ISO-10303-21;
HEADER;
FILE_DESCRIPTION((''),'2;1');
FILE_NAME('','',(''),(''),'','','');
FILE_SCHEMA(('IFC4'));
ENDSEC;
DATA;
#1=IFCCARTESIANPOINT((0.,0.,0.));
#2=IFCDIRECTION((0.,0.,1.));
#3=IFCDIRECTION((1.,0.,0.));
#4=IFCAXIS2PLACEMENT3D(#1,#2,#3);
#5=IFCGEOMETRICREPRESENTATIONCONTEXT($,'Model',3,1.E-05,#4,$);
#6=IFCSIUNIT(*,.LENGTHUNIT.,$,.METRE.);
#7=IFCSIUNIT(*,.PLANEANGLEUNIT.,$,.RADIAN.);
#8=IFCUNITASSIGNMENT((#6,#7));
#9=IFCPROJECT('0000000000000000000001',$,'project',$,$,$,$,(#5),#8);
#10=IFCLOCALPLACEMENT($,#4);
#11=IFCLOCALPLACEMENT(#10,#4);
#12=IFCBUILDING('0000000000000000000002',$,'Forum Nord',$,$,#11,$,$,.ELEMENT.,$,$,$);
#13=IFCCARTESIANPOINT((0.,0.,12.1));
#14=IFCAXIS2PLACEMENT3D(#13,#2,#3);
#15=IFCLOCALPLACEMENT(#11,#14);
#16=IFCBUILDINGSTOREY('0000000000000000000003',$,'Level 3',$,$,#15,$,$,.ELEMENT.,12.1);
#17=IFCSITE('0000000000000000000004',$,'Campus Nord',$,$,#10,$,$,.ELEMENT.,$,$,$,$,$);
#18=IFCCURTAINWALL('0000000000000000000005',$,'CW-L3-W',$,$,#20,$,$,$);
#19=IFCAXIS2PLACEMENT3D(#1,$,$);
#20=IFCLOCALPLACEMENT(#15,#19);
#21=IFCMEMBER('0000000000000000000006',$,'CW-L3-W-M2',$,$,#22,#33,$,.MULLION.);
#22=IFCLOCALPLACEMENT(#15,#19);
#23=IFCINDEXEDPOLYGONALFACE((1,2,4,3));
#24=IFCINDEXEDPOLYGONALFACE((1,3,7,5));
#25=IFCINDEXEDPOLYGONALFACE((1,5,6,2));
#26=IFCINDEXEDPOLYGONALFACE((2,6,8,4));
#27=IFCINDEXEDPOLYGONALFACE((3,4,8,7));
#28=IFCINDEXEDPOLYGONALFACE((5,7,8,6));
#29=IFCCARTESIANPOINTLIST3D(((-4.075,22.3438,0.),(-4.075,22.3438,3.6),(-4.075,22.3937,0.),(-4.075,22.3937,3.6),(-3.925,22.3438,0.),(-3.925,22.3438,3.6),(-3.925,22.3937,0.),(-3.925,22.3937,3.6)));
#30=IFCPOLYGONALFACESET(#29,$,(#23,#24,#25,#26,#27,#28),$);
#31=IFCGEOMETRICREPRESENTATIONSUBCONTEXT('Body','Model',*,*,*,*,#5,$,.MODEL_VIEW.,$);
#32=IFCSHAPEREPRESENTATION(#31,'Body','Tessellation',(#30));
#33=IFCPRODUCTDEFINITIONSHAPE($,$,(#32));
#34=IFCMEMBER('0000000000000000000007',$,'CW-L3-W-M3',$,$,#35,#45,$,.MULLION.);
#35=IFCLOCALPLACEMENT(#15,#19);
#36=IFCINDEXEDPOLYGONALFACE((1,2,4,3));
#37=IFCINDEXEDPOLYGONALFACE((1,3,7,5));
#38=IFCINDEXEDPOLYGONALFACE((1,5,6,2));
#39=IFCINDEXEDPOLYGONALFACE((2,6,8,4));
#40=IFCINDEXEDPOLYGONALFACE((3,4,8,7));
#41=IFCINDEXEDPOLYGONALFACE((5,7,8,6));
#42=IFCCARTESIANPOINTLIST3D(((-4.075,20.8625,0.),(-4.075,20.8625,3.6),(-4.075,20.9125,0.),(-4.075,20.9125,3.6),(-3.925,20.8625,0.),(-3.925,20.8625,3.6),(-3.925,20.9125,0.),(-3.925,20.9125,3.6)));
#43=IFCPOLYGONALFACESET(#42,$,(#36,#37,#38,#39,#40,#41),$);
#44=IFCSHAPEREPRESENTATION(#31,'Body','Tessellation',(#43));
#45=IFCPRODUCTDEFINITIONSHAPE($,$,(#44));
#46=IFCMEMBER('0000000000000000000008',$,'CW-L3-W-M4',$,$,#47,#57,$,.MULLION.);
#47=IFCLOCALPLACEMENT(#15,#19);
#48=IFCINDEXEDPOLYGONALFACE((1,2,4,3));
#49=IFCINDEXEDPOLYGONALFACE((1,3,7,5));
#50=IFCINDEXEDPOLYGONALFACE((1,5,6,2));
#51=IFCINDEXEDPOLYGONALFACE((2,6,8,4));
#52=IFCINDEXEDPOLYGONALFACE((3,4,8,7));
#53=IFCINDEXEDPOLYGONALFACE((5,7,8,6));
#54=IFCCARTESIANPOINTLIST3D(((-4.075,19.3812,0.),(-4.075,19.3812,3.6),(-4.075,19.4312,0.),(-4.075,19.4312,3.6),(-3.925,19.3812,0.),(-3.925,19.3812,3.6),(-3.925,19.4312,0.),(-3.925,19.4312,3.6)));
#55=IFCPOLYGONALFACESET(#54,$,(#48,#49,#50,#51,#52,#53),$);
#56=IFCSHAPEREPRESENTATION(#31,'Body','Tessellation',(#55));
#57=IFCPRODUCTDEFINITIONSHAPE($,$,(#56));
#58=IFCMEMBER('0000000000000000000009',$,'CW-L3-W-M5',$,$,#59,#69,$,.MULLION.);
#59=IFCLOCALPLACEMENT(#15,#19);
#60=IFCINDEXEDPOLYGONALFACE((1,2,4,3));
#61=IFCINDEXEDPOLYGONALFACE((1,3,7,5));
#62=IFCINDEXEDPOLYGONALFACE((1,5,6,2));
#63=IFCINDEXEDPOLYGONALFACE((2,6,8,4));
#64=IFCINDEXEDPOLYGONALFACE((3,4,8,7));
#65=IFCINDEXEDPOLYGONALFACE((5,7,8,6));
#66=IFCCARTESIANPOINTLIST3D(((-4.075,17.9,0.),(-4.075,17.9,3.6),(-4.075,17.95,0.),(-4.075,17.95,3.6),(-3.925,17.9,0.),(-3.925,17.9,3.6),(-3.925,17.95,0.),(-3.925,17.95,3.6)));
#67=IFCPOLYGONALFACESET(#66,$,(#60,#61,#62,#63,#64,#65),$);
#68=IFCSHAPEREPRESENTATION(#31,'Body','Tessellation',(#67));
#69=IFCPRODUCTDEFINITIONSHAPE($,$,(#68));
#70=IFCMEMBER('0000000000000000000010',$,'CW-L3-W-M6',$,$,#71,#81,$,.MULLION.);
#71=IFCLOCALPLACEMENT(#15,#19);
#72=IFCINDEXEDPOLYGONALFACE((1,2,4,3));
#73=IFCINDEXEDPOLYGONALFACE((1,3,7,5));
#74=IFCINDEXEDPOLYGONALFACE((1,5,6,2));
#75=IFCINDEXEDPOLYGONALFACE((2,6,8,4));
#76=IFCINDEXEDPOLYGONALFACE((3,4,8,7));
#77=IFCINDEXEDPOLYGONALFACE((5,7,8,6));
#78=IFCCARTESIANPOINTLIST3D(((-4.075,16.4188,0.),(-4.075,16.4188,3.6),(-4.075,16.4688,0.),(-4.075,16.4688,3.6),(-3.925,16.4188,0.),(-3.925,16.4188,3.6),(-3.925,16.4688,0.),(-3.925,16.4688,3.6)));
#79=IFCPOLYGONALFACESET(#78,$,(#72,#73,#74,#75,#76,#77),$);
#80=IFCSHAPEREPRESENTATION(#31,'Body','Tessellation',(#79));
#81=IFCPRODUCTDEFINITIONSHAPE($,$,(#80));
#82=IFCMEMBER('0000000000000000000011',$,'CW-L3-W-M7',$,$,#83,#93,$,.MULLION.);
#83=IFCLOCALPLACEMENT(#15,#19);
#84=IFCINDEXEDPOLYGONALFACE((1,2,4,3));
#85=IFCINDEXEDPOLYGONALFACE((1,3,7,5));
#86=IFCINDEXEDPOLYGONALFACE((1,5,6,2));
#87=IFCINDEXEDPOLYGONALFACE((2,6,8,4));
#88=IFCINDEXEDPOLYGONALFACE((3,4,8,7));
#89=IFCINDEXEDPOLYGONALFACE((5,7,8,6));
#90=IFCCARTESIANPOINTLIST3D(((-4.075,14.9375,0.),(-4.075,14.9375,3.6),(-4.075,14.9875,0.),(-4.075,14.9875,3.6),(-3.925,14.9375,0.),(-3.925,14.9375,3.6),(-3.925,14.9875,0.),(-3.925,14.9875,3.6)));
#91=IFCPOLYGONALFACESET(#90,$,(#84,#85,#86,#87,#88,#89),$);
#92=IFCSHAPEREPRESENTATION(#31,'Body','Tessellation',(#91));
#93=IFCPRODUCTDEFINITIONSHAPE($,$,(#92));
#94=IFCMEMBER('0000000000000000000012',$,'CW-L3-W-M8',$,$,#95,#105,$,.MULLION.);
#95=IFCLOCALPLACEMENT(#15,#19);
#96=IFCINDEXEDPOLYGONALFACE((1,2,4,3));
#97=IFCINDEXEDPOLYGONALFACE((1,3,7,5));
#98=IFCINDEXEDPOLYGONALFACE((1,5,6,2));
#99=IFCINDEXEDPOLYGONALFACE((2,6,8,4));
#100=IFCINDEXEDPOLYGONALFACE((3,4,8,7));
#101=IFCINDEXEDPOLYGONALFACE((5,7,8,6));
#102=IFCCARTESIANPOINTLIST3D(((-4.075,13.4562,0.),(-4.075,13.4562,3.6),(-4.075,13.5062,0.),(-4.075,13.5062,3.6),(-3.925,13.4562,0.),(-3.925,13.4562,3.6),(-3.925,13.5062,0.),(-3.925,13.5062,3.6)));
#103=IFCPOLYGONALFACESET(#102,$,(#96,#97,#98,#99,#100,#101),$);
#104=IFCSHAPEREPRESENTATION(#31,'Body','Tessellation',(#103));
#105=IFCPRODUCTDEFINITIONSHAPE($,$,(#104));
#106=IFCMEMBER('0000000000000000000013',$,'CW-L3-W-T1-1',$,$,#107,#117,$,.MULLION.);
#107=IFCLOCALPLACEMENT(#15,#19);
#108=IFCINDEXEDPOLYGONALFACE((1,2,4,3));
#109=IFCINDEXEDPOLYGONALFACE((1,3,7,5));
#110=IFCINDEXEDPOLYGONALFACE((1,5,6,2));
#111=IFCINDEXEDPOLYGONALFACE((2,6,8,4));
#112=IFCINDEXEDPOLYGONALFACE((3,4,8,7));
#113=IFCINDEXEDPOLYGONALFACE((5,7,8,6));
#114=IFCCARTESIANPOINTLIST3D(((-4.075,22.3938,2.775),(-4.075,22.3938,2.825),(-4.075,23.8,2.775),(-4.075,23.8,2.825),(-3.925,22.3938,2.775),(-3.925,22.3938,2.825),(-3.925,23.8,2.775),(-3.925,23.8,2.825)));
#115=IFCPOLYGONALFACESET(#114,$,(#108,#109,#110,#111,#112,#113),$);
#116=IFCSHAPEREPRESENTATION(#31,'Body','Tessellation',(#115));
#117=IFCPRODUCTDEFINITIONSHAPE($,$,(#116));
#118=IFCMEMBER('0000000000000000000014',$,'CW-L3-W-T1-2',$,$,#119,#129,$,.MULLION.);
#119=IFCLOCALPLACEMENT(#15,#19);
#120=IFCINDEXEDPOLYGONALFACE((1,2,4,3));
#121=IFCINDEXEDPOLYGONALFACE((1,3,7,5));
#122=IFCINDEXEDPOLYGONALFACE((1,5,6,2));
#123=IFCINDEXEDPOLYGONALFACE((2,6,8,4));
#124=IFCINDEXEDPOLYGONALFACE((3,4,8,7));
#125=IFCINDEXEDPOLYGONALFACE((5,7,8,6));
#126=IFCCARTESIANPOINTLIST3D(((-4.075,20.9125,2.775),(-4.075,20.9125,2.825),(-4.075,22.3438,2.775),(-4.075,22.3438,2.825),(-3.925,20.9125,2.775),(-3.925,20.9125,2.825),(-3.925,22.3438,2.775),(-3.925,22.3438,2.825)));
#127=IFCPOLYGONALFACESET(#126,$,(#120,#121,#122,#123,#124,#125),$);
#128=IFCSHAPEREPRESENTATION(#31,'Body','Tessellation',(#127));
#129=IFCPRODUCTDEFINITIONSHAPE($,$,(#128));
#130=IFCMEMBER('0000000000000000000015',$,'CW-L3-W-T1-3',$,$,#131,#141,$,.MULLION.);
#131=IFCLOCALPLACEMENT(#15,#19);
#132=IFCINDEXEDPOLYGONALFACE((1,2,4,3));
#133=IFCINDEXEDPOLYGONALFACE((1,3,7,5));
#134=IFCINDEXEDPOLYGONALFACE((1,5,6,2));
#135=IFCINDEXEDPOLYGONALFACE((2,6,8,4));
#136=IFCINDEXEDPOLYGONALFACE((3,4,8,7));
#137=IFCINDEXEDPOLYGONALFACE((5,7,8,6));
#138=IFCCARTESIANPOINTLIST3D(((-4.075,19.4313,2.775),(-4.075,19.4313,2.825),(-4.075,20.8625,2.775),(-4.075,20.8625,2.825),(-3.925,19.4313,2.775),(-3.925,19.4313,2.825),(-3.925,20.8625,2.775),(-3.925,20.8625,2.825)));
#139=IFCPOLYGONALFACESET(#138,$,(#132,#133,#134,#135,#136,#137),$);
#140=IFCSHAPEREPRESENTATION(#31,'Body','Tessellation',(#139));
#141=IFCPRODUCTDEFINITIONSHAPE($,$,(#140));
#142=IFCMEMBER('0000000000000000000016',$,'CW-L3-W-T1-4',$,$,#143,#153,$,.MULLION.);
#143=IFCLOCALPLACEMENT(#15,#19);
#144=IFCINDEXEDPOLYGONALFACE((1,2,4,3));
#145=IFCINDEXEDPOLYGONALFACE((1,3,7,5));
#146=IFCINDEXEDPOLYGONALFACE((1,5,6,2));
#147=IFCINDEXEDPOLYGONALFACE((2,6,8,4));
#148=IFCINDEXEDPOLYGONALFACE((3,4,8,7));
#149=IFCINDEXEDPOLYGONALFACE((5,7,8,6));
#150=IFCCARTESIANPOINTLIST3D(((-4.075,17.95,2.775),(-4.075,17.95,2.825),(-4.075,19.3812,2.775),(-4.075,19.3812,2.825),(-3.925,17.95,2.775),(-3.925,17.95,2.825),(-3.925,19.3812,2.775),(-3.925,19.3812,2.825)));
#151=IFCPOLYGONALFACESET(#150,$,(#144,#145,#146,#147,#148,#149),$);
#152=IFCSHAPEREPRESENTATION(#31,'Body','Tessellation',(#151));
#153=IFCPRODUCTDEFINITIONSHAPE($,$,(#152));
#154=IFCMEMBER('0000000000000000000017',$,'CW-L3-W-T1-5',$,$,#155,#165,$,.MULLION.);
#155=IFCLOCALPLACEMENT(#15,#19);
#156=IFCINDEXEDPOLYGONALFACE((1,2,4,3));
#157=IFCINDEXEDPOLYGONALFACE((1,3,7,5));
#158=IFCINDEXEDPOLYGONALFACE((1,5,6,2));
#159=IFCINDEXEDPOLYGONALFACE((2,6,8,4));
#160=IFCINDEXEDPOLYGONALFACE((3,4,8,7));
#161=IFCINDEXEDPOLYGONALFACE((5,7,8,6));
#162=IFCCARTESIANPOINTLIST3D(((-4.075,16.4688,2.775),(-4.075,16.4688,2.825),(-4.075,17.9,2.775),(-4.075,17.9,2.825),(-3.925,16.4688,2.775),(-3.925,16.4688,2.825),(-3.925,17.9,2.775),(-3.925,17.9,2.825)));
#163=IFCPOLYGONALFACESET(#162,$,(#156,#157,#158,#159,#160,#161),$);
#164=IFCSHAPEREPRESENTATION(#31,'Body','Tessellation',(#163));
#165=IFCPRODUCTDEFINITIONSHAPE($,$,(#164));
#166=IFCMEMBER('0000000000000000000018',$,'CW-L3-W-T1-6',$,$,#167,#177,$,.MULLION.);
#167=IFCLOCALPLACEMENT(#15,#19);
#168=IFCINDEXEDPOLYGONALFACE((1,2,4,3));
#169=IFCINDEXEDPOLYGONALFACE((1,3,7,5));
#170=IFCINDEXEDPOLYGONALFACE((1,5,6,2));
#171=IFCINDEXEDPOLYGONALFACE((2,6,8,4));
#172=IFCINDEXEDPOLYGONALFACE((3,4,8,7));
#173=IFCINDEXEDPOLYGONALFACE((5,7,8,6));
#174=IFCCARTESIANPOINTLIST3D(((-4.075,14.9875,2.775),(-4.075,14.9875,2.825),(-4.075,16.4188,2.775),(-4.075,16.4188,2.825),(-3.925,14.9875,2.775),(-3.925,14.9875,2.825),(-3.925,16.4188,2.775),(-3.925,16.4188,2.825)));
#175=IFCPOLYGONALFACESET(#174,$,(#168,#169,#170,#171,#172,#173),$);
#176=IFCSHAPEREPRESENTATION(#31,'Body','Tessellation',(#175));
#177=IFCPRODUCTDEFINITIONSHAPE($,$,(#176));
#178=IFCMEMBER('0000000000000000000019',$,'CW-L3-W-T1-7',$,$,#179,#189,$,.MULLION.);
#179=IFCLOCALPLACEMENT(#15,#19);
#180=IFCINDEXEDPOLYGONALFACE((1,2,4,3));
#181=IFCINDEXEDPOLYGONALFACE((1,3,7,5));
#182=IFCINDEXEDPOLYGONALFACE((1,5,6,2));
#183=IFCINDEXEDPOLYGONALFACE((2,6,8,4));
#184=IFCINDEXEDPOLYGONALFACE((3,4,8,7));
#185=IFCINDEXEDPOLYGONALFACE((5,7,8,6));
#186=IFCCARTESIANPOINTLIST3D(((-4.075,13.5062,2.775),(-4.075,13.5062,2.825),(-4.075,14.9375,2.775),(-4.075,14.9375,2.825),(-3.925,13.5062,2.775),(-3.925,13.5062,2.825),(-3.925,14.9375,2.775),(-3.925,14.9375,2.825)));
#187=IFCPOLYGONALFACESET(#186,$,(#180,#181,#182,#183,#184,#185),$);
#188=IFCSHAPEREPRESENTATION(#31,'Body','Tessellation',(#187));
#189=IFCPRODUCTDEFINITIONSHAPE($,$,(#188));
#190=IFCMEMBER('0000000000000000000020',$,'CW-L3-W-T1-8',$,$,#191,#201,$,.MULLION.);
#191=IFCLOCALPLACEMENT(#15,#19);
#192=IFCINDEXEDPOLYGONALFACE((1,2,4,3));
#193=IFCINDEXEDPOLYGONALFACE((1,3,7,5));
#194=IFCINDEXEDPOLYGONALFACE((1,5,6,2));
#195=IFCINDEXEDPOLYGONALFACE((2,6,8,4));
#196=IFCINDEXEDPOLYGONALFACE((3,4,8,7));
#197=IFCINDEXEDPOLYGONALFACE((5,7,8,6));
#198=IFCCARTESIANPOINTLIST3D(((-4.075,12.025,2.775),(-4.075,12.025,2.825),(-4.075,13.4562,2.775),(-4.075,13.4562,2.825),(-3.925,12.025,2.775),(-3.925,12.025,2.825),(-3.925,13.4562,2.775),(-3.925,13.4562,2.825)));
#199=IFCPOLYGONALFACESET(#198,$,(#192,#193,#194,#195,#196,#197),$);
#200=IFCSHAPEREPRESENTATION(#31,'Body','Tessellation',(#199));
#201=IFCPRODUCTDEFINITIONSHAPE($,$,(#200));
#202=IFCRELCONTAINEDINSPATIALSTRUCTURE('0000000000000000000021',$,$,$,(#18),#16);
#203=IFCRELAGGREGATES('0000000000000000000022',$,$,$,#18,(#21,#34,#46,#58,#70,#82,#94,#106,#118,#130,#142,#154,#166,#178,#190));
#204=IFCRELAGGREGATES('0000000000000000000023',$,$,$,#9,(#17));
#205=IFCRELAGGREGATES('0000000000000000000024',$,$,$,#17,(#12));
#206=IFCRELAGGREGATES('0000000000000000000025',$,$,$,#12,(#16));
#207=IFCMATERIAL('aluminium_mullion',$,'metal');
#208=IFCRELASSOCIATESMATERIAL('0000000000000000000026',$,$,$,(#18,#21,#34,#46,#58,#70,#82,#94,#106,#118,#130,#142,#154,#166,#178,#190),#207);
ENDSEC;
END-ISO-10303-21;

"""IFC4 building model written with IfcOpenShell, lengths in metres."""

from ifc_helpers import new_model, si_unit, frame, origin_with_axes, origin_2d_with_axis, place, context, subcontext, project, spatial, rectangle, extrude, material, element, aggregate, save


model = new_model("IFC4")

# Units and contexts
model_context = context("Model", 3, precision=1e-05, world=origin_with_axes())
body_context = subcontext(model_context, "Body", "Model", "MODEL_VIEW")
ifc_project = project(units=[si_unit("LENGTHUNIT", "METRE"), si_unit("PLANEANGLEUNIT", "RADIAN")], contexts=[model_context])

# Site, building, storey
site_placement = place(None, origin_with_axes())
site = spatial("IfcSite", under=ifc_project, at=site_placement, Name="Campus Nord", CompositionType="ELEMENT")
building_placement = place(site_placement, origin_with_axes())
building = spatial("IfcBuilding", under=site, at=building_placement, Name="Forum Nord", CompositionType="ELEMENT")
storey_placement = place(building_placement, frame((0.0, 0.0, 12.1), z_axis=(0.0, 0.0, 1.0), x_axis=(1.0, 0.0, 0.0)))
storey = spatial("IfcBuildingStorey", under=building, at=storey_placement, Name="Level 3", CompositionType="ELEMENT", Elevation=12.1)

# Curtain wall, members
ifc_material_1 = material(Name="aluminium_mullion", Category="metal")
curtain_wall_placement = place(storey_placement, origin_with_axes())
curtain_wall = element("IfcCurtainWall", 1, at=curtain_wall_placement, inside=storey, material=ifc_material_1, Name="CW-L3-W")
member_1_placement = place(storey_placement, frame((-4.0, 22.3687, 0.0), z_axis=(0.0, 0.0, 1.0), x_axis=(0.0, -1.0, 0.0)))
member_1 = element("IfcMember", 2, at=member_1_placement, material=ifc_material_1, Name="CW-L3-W-M2", PredefinedType="MULLION", context=body_context, shape_type="SweptSolid", body=[
    extrude(rectangle(XDim=0.05, YDim=0.15, at=origin_2d_with_axis()), origin_with_axes(), (0.0, 0.0, 1.0), 3.6),
])
member_2_placement = place(storey_placement, frame((-4.0, 20.8875, 0.0), z_axis=(0.0, 0.0, 1.0), x_axis=(0.0, -1.0, 0.0)))
member_2 = element("IfcMember", 3, at=member_2_placement, material=ifc_material_1, Name="CW-L3-W-M3", PredefinedType="MULLION", context=body_context, shape_type="SweptSolid", body=[
    extrude(rectangle(XDim=0.05, YDim=0.15, at=origin_2d_with_axis()), origin_with_axes(), (0.0, 0.0, 1.0), 3.6),
])
member_3_placement = place(storey_placement, frame((-4.0, 19.4062, 0.0), z_axis=(0.0, 0.0, 1.0), x_axis=(0.0, -1.0, 0.0)))
member_3 = element("IfcMember", 4, at=member_3_placement, material=ifc_material_1, Name="CW-L3-W-M4", PredefinedType="MULLION", context=body_context, shape_type="SweptSolid", body=[
    extrude(rectangle(XDim=0.05, YDim=0.15, at=origin_2d_with_axis()), origin_with_axes(), (0.0, 0.0, 1.0), 3.6),
])
member_4_placement = place(storey_placement, frame((-4.0, 17.925, 0.0), z_axis=(0.0, 0.0, 1.0), x_axis=(0.0, -1.0, 0.0)))
member_4 = element("IfcMember", 5, at=member_4_placement, material=ifc_material_1, Name="CW-L3-W-M5", PredefinedType="MULLION", context=body_context, shape_type="SweptSolid", body=[
    extrude(rectangle(XDim=0.05, YDim=0.15, at=origin_2d_with_axis()), origin_with_axes(), (0.0, 0.0, 1.0), 3.6),
])
member_5_placement = place(storey_placement, frame((-4.0, 16.4438, 0.0), z_axis=(0.0, 0.0, 1.0), x_axis=(0.0, -1.0, 0.0)))
member_5 = element("IfcMember", 6, at=member_5_placement, material=ifc_material_1, Name="CW-L3-W-M6", PredefinedType="MULLION", context=body_context, shape_type="SweptSolid", body=[
    extrude(rectangle(XDim=0.05, YDim=0.15, at=origin_2d_with_axis()), origin_with_axes(), (0.0, 0.0, 1.0), 3.6),
])
member_6_placement = place(storey_placement, frame((-4.0, 14.9625, 0.0), z_axis=(0.0, 0.0, 1.0), x_axis=(0.0, -1.0, 0.0)))
member_6 = element("IfcMember", 7, at=member_6_placement, material=ifc_material_1, Name="CW-L3-W-M7", PredefinedType="MULLION", context=body_context, shape_type="SweptSolid", body=[
    extrude(rectangle(XDim=0.05, YDim=0.15, at=origin_2d_with_axis()), origin_with_axes(), (0.0, 0.0, 1.0), 3.6),
])
member_7_placement = place(storey_placement, frame((-4.0, 13.4812, 0.0), z_axis=(0.0, 0.0, 1.0), x_axis=(0.0, -1.0, 0.0)))
member_7 = element("IfcMember", 8, at=member_7_placement, material=ifc_material_1, Name="CW-L3-W-M8", PredefinedType="MULLION", context=body_context, shape_type="SweptSolid", body=[
    extrude(rectangle(XDim=0.05, YDim=0.15, at=origin_2d_with_axis()), origin_with_axes(), (0.0, 0.0, 1.0), 3.6),
])
member_8_placement = place(storey_placement, frame((-4.0, 23.8, 2.8), z_axis=(0.0, -1.0, 0.0), x_axis=(1.0, 0.0, 0.0)))
member_8 = element("IfcMember", 9, at=member_8_placement, material=ifc_material_1, Name="CW-L3-W-T1-1", PredefinedType="MULLION", context=body_context, shape_type="SweptSolid", body=[
    extrude(rectangle(XDim=0.15, YDim=0.05, at=origin_2d_with_axis()), origin_with_axes(), (0.0, 0.0, 1.0), 1.4062),
])
member_9_placement = place(storey_placement, frame((-4.0, 22.3438, 2.8), z_axis=(0.0, -1.0, 0.0), x_axis=(1.0, 0.0, 0.0)))
member_9 = element("IfcMember", 10, at=member_9_placement, material=ifc_material_1, Name="CW-L3-W-T1-2", PredefinedType="MULLION", context=body_context, shape_type="SweptSolid", body=[
    extrude(rectangle(XDim=0.15, YDim=0.05, at=origin_2d_with_axis()), origin_with_axes(), (0.0, 0.0, 1.0), 1.4312),
])
member_10_placement = place(storey_placement, frame((-4.0, 20.8625, 2.8), z_axis=(0.0, -1.0, 0.0), x_axis=(1.0, 0.0, 0.0)))
member_10 = element("IfcMember", 11, at=member_10_placement, material=ifc_material_1, Name="CW-L3-W-T1-3", PredefinedType="MULLION", context=body_context, shape_type="SweptSolid", body=[
    extrude(rectangle(XDim=0.15, YDim=0.05, at=origin_2d_with_axis()), origin_with_axes(), (0.0, 0.0, 1.0), 1.4312),
])
member_11_placement = place(storey_placement, frame((-4.0, 19.3813, 2.8), z_axis=(0.0, -1.0, 0.0), x_axis=(1.0, 0.0, 0.0)))
member_11 = element("IfcMember", 12, at=member_11_placement, material=ifc_material_1, Name="CW-L3-W-T1-4", PredefinedType="MULLION", context=body_context, shape_type="SweptSolid", body=[
    extrude(rectangle(XDim=0.15, YDim=0.05, at=origin_2d_with_axis()), origin_with_axes(), (0.0, 0.0, 1.0), 1.4312),
])
member_12_placement = place(storey_placement, frame((-4.0, 17.9, 2.8), z_axis=(0.0, -1.0, 0.0), x_axis=(1.0, 0.0, 0.0)))
member_12 = element("IfcMember", 13, at=member_12_placement, material=ifc_material_1, Name="CW-L3-W-T1-5", PredefinedType="MULLION", context=body_context, shape_type="SweptSolid", body=[
    extrude(rectangle(XDim=0.15, YDim=0.05, at=origin_2d_with_axis()), origin_with_axes(), (0.0, 0.0, 1.0), 1.4312),
])
member_13_placement = place(storey_placement, frame((-4.0, 16.4187, 2.8), z_axis=(0.0, -1.0, 0.0), x_axis=(1.0, 0.0, 0.0)))
member_13 = element("IfcMember", 14, at=member_13_placement, material=ifc_material_1, Name="CW-L3-W-T1-6", PredefinedType="MULLION", context=body_context, shape_type="SweptSolid", body=[
    extrude(rectangle(XDim=0.15, YDim=0.05, at=origin_2d_with_axis()), origin_with_axes(), (0.0, 0.0, 1.0), 1.4312),
])
member_14_placement = place(storey_placement, frame((-4.0, 14.9375, 2.8), z_axis=(0.0, -1.0, 0.0), x_axis=(1.0, 0.0, 0.0)))
member_14 = element("IfcMember", 15, at=member_14_placement, material=ifc_material_1, Name="CW-L3-W-T1-7", PredefinedType="MULLION", context=body_context, shape_type="SweptSolid", body=[
    extrude(rectangle(XDim=0.15, YDim=0.05, at=origin_2d_with_axis()), origin_with_axes(), (0.0, 0.0, 1.0), 1.4312),
])
member_15_placement = place(storey_placement, frame((-4.0, 13.4563, 2.8), z_axis=(0.0, -1.0, 0.0), x_axis=(1.0, 0.0, 0.0)))
member_15 = element("IfcMember", 16, at=member_15_placement, material=ifc_material_1, Name="CW-L3-W-T1-8", PredefinedType="MULLION", context=body_context, shape_type="SweptSolid", body=[
    extrude(rectangle(XDim=0.15, YDim=0.05, at=origin_2d_with_axis()), origin_with_axes(), (0.0, 0.0, 1.0), 1.4312),
])
aggregate(curtain_wall, [member_1, member_2, member_3, member_4, member_5, member_6, member_7, member_8, member_9, member_10, member_11, member_12, member_13, member_14, member_15])

save(model, "model.ifc")
